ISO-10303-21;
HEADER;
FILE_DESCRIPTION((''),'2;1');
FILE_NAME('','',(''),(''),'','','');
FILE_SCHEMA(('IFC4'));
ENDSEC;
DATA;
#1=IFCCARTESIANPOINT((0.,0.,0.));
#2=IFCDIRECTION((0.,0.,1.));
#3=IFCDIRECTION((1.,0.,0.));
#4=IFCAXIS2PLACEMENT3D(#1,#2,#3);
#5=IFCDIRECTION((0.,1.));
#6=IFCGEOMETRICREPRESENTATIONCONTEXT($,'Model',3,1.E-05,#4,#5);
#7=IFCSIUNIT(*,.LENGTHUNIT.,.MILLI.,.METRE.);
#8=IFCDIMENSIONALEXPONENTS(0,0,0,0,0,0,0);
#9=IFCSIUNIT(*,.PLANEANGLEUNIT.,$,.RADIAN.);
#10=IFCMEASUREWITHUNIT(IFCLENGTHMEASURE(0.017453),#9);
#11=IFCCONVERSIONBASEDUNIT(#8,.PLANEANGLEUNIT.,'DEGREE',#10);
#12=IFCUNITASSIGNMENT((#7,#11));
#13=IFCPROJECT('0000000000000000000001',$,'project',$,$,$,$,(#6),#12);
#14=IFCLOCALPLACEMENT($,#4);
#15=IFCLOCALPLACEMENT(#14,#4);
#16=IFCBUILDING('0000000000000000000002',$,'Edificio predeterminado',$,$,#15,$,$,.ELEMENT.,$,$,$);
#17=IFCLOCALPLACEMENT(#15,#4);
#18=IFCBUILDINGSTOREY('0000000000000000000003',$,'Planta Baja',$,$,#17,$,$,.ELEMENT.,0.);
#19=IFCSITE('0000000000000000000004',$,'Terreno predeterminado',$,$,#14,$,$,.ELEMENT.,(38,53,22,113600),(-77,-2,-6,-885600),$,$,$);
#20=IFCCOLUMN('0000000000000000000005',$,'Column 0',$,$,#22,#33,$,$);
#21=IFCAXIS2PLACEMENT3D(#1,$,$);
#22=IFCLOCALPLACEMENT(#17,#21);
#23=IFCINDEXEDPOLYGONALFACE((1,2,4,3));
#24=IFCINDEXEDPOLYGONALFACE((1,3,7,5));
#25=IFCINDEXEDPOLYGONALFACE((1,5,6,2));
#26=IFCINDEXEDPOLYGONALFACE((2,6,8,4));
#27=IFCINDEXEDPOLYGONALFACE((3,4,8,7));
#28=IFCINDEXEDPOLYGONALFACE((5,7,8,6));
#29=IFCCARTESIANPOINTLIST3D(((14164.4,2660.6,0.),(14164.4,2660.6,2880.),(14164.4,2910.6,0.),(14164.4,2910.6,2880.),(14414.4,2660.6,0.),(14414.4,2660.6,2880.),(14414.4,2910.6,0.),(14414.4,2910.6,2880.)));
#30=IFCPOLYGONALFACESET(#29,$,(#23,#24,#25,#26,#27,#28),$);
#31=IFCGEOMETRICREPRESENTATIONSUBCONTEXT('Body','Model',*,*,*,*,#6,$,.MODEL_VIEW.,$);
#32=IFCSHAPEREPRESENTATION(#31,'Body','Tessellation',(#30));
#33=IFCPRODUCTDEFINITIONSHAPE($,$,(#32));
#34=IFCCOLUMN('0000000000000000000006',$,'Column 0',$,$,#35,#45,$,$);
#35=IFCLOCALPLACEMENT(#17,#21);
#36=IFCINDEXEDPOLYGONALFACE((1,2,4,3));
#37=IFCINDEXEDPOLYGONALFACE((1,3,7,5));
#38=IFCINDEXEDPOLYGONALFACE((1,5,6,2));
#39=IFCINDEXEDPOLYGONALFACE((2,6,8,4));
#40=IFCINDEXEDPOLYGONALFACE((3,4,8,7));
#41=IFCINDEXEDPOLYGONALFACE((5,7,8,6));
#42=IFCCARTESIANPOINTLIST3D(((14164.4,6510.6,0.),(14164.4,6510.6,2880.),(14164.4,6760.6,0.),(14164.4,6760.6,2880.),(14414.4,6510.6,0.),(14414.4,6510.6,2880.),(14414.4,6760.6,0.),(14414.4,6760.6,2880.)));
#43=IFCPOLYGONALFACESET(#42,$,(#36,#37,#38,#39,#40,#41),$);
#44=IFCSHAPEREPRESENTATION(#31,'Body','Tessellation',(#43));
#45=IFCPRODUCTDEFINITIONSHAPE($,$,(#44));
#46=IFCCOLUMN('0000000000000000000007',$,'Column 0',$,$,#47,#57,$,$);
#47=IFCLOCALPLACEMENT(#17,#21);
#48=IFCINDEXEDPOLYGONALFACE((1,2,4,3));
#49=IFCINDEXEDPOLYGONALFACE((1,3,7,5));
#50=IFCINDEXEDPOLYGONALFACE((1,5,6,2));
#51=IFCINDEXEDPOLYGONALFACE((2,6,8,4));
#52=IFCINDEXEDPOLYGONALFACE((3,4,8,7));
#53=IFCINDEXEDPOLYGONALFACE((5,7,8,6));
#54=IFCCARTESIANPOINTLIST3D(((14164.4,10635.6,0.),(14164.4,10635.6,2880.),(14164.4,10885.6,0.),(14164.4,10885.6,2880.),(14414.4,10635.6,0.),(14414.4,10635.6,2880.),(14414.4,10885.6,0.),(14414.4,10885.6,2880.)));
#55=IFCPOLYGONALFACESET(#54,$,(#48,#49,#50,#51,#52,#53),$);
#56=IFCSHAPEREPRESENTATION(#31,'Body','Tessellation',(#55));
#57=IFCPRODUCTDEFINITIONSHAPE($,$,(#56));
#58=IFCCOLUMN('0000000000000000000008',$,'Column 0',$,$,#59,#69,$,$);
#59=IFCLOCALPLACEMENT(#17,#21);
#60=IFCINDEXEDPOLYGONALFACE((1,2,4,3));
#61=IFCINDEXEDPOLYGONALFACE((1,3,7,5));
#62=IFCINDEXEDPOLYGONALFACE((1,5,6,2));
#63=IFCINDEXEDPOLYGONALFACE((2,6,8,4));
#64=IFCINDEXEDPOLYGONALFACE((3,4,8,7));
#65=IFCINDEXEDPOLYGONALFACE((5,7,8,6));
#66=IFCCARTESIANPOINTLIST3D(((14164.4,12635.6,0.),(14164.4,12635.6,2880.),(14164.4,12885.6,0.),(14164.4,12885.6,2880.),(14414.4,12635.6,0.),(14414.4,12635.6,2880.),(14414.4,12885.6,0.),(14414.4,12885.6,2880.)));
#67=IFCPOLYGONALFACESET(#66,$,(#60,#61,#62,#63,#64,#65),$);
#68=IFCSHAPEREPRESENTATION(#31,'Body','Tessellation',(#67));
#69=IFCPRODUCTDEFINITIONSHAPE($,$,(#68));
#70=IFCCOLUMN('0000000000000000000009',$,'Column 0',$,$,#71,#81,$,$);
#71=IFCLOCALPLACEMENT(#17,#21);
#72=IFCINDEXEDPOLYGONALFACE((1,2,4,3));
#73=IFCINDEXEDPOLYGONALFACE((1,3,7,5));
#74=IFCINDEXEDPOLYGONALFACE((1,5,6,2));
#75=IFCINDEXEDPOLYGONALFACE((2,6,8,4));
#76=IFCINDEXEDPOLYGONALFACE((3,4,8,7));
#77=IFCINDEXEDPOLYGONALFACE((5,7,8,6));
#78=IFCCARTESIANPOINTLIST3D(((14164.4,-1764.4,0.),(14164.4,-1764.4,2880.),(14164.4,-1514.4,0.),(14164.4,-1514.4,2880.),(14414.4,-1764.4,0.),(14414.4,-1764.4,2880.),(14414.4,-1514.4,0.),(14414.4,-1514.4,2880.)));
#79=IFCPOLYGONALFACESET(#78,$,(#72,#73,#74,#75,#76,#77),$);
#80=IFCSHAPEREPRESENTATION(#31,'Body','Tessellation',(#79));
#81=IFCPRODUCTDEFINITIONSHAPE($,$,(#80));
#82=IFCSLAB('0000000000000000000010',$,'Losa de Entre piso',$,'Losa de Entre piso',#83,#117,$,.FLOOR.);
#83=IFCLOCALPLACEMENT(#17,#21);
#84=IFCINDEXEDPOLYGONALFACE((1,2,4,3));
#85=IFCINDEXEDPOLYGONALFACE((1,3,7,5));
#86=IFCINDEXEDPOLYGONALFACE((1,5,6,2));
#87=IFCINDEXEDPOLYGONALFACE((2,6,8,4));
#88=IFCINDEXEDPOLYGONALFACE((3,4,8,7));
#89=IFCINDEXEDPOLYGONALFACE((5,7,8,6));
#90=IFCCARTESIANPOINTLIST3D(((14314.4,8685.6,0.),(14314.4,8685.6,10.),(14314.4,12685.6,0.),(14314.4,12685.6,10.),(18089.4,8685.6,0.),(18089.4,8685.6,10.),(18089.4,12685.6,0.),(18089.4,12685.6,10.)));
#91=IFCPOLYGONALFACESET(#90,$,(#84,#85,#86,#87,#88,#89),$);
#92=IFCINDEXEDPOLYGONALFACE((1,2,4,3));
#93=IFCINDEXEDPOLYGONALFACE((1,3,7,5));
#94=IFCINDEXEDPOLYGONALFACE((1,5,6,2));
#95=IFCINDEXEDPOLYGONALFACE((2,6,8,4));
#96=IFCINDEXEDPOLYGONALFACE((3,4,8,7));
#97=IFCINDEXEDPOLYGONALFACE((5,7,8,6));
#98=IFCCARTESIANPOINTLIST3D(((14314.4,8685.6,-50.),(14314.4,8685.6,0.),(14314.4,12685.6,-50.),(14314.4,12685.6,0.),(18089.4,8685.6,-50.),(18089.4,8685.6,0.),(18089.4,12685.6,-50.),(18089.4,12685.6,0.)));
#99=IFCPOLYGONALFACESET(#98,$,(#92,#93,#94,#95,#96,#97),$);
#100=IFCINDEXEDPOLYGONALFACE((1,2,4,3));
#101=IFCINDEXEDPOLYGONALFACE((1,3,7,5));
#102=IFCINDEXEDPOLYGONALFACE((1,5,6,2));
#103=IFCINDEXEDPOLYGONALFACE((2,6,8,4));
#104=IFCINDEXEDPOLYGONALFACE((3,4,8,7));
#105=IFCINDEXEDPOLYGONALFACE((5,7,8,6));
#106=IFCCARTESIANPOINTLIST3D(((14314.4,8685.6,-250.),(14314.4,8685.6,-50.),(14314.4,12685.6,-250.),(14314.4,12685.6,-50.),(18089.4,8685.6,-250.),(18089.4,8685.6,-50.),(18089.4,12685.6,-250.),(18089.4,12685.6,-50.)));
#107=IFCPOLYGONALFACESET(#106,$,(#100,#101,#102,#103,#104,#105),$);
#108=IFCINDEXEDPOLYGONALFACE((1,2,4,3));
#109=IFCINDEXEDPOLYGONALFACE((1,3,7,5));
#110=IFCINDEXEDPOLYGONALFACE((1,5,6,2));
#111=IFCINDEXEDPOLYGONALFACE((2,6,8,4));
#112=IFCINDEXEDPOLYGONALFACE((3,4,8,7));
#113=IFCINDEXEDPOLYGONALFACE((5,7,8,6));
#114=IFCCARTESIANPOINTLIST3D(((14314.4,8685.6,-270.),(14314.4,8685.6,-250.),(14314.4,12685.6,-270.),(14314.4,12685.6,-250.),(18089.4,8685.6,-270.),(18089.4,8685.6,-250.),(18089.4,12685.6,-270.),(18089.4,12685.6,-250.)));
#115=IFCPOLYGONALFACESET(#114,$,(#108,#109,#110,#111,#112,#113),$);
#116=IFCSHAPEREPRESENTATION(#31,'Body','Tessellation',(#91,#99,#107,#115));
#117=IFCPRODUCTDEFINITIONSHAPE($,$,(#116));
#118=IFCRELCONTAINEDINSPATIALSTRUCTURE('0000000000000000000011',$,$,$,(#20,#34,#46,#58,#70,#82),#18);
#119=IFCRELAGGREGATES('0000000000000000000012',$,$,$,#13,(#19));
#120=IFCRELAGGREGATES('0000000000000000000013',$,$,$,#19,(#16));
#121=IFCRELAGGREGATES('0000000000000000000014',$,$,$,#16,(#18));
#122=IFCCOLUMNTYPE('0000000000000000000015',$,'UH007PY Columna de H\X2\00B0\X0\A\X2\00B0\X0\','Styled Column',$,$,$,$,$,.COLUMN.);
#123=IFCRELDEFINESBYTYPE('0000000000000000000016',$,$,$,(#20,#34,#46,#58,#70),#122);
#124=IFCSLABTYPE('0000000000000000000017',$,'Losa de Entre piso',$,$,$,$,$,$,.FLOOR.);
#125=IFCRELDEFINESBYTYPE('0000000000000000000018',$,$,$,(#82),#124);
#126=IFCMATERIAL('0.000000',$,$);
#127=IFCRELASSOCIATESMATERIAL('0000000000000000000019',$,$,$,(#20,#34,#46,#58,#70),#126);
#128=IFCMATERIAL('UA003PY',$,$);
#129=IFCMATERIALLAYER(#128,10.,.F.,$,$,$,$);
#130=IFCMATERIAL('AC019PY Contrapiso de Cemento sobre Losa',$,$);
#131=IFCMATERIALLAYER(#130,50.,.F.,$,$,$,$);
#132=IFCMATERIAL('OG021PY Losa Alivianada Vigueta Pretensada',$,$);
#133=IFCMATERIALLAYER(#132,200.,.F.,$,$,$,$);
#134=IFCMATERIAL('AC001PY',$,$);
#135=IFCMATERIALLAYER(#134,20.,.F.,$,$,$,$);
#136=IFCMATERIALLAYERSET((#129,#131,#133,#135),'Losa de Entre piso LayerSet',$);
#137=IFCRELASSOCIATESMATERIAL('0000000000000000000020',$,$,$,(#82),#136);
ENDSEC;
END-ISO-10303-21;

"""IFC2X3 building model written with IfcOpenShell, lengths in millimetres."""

from ifc_helpers import new_model, entity, si_unit, converted_unit, direction, frame, origin_with_axes, place, context, subcontext, project, spatial, polyline, outline, extrude, material, layer, layer_set, layer_usage, type_object, element, save


model = new_model("IFC2X3")

# Units and contexts
model_context = context("Model", 3, precision=1e-05, world=origin_with_axes(), true_north=direction((0.0, 1.0)))
body_context = subcontext(model_context, "Body", "Model", "MODEL_VIEW")
ifc_project = project(units=[si_unit("LENGTHUNIT", "METRE", prefix="MILLI"), converted_unit("PLANEANGLEUNIT", "DEGREE", entity("IfcLengthMeasure", 0.017453), si_unit("PLANEANGLEUNIT", "RADIAN"), dimensions=[0, 0, 0, 0, 0, 0, 0])], contexts=[model_context])

# Site, building, storey
site_placement = place(None, origin_with_axes())
site = spatial("IfcSite", under=ifc_project, at=site_placement, Name="Terreno predeterminado", CompositionType="ELEMENT", RefLatitude=(38, 53, 22, 113600), RefLongitude=(-77, -2, -6, -885600))
building_placement = place(site_placement, origin_with_axes())
building = spatial("IfcBuilding", under=site, at=building_placement, Name="Edificio predeterminado", CompositionType="ELEMENT")
storey_placement = place(building_placement, origin_with_axes())
storey = spatial("IfcBuildingStorey", under=building, at=storey_placement, Name="Planta Baja", CompositionType="ELEMENT", Elevation=0.0)

# Columns
ifc_material_1 = material(Name="0.000000")
column_type = type_object("IfcColumnType", Name="UH007PY Columna de H°A°", Description="Styled Column", PredefinedType="COLUMN")
for number, where, z_axis, x_axis, name in (
    (1, (14289.4, 2785.6, 0.0), (0.0, 0.0, 1.0), (1.0, 0.0, 0.0), "Column 0"),
    (2, (14289.4, 6635.6, 0.0), (0.0, 0.0, 1.0), (1.0, 0.0, 0.0), "Column 0"),
    (3, (14289.4, 10760.6, 0.0), (0.0, 0.0, 1.0), (1.0, 0.0, 0.0), "Column 0"),
    (4, (14289.4, 12760.6, 0.0), (0.0, 0.0, 1.0), (1.0, 0.0, 0.0), "Column 0"),
    (5, (14289.4, -1639.4, 0.0), (0.0, 0.0, 1.0), (1.0, 0.0, 0.0), "Column 0"),
):
    element("IfcColumn", number, at=place(storey_placement, frame(where, z_axis=z_axis, x_axis=x_axis)), inside=storey, type_object=column_type, material=ifc_material_1, Name=name, context=body_context, shape_type="SweptSolid", body=[
        extrude(outline(polyline([(-125.0, -125.0), (125.0, -125.0), (125.0, 125.0), (-125.0, 125.0), (-125.0, -125.0)])), origin_with_axes(), (0.0, 0.0, 1.0), 2880.0),
    ])

# Slab
ifc_material_2 = material(Name="UA003PY")
ifc_layer_1 = layer(ifc_material_2, 10.0, ventilated=False)
ifc_material_3 = material(Name="AC019PY Contrapiso de Cemento sobre Losa")
ifc_layer_2 = layer(ifc_material_3, 50.0, ventilated=False)
ifc_material_4 = material(Name="OG021PY Losa Alivianada Vigueta Pretensada")
ifc_layer_3 = layer(ifc_material_4, 200.0, ventilated=False)
ifc_material_5 = material(Name="AC001PY")
ifc_layer_4 = layer(ifc_material_5, 20.0, ventilated=False)
ifc_layer_set_1 = layer_set([ifc_layer_1, ifc_layer_2, ifc_layer_3, ifc_layer_4], Name="Losa de Entre piso LayerSet")
ifc_layer_usage_1 = layer_usage(ifc_layer_set_1, "AXIS3", "NEGATIVE", 0.0)
slab_type = type_object("IfcSlabType", Name="Losa de Entre piso", PredefinedType="FLOOR")
slab_1_placement = place(storey_placement, origin_with_axes())
element("IfcSlab", 6, at=slab_1_placement, inside=storey, type_object=slab_type, material=ifc_layer_usage_1, Name="Losa de Entre piso", ObjectType="Losa de Entre piso", PredefinedType="FLOOR", context=body_context, shape_type="SweptSolid", body=[
    extrude(outline(polyline([(0.0, 4000.0), (3775.0, 4000.0), (3775.0, 0.0), (0.0, 0.0), (0.0, 4000.0)])), frame((14314.4, 12685.6, 0.0), z_axis=(0.0, 0.0, -1.0), x_axis=(1.0, 0.0, 0.0)), (0.0, 0.0, -1.0), 10.0),
    extrude(outline(polyline([(0.0, 4000.0), (3775.0, 4000.0), (3775.0, 0.0), (0.0, 0.0), (0.0, 4000.0)])), frame((14314.4, 12685.6, -50.0), z_axis=(0.0, 0.0, -1.0), x_axis=(1.0, 0.0, 0.0)), (0.0, 0.0, -1.0), 50.0),
    extrude(outline(polyline([(0.0, 4000.0), (3775.0, 4000.0), (3775.0, 0.0), (0.0, 0.0), (0.0, 4000.0)])), frame((14314.4, 12685.6, -250.0), z_axis=(0.0, 0.0, -1.0), x_axis=(1.0, 0.0, 0.0)), (0.0, 0.0, -1.0), 200.0),
    extrude(outline(polyline([(0.0, 4000.0), (3775.0, 4000.0), (3775.0, 0.0), (0.0, 0.0), (0.0, 4000.0)])), frame((14314.4, 12685.6, -270.0), z_axis=(0.0, 0.0, -1.0), x_axis=(1.0, 0.0, 0.0)), (0.0, 0.0, -1.0), 20.0),
])

save(model, "model.ifc")
